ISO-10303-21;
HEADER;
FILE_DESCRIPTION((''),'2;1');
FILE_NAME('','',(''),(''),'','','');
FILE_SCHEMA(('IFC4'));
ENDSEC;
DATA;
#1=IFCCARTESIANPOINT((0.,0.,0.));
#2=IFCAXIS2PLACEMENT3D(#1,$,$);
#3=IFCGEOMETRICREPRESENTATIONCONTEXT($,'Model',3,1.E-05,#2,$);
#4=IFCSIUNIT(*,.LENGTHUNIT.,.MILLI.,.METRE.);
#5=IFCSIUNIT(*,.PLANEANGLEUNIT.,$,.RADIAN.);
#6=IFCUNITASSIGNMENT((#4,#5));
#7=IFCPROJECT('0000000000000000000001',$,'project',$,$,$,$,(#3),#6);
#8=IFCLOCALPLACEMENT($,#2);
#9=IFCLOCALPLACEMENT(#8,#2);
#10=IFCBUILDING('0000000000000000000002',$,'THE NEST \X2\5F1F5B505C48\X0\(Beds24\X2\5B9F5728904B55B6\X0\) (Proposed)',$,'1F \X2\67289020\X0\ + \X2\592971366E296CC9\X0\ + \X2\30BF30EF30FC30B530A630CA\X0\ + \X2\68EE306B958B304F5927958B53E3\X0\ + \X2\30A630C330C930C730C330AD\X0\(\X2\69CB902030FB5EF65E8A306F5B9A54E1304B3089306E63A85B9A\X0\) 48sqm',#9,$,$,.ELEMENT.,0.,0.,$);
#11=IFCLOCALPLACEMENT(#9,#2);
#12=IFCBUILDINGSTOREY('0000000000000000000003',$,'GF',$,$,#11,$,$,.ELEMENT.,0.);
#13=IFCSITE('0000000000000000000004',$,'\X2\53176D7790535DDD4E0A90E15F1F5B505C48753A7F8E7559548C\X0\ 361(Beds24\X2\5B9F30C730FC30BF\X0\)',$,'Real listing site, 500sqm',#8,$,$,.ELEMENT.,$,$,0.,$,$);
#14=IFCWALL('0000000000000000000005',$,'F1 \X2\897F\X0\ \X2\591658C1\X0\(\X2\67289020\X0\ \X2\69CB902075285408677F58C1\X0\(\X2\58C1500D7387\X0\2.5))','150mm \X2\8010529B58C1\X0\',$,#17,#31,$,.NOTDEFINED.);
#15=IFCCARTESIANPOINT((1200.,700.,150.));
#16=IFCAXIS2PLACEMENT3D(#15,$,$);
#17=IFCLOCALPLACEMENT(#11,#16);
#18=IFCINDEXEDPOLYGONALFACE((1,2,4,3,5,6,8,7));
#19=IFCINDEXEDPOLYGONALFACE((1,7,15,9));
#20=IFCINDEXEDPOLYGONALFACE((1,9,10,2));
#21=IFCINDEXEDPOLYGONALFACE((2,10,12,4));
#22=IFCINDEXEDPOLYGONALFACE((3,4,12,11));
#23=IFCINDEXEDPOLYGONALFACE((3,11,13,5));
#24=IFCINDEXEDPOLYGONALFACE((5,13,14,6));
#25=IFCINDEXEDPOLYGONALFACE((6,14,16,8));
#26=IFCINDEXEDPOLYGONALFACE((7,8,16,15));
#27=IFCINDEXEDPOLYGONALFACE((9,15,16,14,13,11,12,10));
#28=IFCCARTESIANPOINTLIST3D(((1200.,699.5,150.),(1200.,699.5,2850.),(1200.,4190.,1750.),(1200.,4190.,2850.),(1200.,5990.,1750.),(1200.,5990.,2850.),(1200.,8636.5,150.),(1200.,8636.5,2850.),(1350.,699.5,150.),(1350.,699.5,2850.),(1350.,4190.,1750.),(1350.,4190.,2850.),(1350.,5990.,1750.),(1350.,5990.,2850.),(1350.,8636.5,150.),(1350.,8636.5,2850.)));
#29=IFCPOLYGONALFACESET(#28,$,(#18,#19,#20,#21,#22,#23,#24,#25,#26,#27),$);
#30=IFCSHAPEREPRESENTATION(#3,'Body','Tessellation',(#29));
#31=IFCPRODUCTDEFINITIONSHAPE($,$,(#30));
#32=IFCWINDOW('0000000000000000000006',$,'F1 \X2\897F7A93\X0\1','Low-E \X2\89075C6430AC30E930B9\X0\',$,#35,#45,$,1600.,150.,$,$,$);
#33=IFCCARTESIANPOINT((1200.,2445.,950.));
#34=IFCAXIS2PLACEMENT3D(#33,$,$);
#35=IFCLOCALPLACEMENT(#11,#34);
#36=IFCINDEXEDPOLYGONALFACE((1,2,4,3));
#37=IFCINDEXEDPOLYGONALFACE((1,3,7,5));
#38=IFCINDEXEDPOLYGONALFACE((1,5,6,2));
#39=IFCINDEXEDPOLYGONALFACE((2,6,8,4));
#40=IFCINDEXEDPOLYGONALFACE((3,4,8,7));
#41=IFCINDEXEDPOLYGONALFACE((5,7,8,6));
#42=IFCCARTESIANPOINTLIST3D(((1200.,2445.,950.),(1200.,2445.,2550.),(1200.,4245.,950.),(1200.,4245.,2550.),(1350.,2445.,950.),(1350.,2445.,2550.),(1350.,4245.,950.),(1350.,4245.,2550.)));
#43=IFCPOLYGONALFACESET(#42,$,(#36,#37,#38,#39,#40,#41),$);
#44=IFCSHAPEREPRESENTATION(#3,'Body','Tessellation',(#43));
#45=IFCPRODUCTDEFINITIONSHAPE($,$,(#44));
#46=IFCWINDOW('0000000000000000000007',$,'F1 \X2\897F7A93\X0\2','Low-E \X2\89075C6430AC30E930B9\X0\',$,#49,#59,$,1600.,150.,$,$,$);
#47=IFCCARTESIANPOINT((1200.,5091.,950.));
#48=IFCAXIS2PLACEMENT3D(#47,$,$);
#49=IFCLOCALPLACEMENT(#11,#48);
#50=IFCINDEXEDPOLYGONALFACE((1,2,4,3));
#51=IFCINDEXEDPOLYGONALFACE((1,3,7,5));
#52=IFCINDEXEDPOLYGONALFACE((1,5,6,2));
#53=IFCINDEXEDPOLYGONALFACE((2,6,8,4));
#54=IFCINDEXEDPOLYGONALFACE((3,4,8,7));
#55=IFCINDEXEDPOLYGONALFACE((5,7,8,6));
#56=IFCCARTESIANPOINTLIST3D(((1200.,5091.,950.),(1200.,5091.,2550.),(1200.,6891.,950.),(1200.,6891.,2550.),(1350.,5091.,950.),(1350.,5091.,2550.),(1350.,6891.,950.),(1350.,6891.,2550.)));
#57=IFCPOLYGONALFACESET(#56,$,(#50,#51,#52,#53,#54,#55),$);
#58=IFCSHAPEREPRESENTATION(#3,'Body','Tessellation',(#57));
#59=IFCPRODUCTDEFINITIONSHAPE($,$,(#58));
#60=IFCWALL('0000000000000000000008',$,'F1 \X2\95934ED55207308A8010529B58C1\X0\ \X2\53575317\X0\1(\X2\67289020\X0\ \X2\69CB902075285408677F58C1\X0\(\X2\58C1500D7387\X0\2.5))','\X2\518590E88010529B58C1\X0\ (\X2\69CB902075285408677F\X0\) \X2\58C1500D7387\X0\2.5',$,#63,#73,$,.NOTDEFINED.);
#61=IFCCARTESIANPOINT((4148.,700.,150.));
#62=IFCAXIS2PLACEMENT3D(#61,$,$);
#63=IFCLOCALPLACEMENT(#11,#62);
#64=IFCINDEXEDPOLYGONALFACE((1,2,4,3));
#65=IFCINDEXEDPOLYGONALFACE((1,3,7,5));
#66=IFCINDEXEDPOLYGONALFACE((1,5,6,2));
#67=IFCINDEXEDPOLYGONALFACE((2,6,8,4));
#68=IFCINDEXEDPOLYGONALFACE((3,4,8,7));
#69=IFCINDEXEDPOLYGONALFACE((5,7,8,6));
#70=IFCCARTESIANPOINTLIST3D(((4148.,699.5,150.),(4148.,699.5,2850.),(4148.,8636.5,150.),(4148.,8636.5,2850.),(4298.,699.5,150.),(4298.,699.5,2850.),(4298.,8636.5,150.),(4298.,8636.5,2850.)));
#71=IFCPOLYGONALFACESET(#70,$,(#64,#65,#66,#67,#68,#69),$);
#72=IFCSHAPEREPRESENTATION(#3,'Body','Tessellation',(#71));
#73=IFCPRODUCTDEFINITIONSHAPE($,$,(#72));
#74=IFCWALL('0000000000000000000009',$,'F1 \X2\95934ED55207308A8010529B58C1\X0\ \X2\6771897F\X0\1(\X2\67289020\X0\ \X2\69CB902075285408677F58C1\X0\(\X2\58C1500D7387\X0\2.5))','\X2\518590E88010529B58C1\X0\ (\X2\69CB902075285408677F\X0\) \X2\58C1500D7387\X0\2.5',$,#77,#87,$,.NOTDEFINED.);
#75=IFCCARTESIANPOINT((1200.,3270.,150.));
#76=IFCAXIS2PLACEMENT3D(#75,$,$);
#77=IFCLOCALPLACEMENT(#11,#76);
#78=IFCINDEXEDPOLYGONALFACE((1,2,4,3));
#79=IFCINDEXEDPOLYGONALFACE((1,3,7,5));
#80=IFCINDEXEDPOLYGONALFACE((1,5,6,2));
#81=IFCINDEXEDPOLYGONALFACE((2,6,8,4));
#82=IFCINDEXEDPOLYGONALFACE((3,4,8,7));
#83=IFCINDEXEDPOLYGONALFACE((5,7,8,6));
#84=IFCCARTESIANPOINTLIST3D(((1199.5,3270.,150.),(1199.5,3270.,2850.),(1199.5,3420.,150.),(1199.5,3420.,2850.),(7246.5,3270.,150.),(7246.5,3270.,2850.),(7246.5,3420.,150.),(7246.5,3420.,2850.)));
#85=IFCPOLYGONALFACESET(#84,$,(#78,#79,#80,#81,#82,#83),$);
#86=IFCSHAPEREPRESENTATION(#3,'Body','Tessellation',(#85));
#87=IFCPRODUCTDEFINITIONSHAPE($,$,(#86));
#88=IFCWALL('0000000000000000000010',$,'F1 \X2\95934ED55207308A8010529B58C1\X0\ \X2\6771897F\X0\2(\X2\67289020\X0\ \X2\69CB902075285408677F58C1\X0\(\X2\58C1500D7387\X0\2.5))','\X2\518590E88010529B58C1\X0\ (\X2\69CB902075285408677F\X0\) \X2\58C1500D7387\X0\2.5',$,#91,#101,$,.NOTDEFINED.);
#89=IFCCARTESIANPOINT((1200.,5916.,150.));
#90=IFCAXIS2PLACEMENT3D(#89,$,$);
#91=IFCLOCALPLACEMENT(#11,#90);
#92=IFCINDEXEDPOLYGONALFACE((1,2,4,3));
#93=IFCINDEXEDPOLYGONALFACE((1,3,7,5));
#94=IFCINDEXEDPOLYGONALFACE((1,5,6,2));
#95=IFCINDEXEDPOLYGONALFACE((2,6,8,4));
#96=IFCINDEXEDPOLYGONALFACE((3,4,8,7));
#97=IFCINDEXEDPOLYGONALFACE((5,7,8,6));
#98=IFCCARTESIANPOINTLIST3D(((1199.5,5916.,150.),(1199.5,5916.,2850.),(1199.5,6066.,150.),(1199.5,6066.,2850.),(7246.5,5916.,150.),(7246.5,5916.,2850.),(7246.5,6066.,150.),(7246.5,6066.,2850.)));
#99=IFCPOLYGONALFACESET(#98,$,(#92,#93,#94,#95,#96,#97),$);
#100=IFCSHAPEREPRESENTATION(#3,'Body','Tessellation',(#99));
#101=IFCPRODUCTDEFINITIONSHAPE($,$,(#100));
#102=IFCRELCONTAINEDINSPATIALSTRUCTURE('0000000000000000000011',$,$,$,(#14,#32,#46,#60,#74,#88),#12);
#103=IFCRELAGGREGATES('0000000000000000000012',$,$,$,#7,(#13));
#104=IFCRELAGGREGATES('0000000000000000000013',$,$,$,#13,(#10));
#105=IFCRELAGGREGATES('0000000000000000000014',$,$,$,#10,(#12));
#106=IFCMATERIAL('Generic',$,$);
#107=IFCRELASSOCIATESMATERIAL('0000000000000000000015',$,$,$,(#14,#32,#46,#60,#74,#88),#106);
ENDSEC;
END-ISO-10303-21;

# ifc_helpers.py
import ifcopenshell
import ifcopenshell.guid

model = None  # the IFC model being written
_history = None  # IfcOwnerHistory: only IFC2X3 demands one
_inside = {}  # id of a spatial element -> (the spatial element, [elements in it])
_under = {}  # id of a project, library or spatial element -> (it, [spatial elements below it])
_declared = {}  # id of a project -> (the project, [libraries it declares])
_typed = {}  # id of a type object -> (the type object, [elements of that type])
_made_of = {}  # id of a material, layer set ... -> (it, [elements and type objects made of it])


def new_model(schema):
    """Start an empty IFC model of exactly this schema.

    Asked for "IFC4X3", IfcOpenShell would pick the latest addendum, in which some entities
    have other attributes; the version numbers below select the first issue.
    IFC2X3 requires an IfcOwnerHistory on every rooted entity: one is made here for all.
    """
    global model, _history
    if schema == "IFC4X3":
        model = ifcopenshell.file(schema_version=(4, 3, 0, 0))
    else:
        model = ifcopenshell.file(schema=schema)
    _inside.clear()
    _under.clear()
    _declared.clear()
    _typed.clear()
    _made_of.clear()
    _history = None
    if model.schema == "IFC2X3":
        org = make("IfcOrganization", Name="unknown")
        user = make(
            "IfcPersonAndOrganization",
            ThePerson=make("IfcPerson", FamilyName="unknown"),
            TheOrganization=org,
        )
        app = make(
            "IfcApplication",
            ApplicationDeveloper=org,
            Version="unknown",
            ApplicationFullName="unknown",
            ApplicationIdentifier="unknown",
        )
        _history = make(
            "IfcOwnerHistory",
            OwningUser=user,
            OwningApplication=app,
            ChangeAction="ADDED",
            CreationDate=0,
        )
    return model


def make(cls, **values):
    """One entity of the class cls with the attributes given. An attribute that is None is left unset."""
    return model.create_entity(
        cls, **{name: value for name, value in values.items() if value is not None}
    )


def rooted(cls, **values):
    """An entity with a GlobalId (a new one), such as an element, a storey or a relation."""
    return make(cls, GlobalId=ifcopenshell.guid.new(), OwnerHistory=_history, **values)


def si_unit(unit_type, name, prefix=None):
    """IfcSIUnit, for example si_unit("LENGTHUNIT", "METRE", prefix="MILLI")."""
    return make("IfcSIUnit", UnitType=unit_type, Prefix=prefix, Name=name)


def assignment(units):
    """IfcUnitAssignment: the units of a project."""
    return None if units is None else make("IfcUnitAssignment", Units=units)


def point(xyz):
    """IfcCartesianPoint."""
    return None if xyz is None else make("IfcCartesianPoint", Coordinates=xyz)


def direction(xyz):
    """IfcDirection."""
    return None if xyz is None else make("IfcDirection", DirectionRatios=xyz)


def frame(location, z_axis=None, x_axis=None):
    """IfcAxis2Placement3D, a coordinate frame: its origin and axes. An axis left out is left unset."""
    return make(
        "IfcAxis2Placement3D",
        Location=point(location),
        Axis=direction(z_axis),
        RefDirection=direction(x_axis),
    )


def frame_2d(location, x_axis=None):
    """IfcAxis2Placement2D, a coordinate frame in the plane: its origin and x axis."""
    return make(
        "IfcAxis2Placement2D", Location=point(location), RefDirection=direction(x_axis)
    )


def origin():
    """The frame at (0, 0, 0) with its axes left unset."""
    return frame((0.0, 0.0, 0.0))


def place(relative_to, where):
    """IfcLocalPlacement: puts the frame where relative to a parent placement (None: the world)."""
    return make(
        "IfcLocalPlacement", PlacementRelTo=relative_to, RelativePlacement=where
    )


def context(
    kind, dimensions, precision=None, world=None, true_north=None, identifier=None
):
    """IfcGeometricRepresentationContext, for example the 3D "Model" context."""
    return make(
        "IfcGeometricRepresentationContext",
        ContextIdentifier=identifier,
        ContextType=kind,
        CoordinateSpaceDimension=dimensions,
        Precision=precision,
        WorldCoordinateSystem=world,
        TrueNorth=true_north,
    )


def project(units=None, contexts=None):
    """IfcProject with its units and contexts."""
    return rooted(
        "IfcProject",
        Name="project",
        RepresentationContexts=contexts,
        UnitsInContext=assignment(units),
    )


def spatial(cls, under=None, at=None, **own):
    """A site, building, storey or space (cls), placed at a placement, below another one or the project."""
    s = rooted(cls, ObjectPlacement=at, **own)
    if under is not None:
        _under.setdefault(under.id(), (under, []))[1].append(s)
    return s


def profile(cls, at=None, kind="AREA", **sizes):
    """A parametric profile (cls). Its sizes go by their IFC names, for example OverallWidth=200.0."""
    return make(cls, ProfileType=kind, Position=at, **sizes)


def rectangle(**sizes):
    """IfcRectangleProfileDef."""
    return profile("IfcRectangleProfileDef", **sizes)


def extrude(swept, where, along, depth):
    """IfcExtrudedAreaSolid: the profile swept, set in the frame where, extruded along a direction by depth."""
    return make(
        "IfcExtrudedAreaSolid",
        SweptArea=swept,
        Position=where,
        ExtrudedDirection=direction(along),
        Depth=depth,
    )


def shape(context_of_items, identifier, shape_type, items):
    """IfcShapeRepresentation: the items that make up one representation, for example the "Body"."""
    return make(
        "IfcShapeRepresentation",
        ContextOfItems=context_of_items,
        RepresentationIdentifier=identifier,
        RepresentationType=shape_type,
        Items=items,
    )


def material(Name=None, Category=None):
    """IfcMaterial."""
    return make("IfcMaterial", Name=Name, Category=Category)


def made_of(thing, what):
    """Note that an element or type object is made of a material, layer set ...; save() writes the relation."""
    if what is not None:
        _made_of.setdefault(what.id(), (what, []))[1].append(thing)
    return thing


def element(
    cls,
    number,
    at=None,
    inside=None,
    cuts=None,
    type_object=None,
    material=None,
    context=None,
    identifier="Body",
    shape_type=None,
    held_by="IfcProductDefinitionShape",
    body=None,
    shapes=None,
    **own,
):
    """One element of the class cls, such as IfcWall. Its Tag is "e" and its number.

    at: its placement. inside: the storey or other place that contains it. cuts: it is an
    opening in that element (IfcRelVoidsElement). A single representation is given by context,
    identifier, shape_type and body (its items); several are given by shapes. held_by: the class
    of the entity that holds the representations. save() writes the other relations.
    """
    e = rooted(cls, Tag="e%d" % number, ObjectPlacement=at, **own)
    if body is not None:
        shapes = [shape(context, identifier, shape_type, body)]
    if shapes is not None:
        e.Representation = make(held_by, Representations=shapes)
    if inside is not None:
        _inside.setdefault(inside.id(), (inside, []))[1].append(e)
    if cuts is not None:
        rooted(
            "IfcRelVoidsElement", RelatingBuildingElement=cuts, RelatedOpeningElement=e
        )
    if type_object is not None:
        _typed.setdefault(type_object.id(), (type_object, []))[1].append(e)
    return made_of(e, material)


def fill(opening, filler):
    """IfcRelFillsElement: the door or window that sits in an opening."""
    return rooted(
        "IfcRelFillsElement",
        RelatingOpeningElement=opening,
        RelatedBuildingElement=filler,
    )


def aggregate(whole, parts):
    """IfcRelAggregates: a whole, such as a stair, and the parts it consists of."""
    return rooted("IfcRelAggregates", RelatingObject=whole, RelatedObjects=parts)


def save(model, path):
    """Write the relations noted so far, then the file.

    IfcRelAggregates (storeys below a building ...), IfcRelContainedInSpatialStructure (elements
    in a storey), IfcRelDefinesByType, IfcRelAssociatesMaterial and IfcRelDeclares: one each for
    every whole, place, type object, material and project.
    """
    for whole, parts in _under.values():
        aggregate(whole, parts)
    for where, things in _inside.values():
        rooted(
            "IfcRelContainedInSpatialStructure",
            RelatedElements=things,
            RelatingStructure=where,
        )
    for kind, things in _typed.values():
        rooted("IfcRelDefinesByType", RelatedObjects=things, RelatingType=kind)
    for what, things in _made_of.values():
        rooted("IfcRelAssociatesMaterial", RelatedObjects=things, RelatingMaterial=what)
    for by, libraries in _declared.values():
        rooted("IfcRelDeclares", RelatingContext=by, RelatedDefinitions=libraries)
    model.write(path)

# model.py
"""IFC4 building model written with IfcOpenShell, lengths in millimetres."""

from ifc_helpers import new_model, si_unit, frame, frame_2d, origin, place, context, project, spatial, rectangle, extrude, material, element, fill, save


model = new_model("IFC4")

# Units and contexts
model_context = context("Model", 3, precision=1e-05, world=origin())
ifc_project = project(units=[si_unit("LENGTHUNIT", "METRE", prefix="MILLI"), si_unit("PLANEANGLEUNIT", "RADIAN")], contexts=[model_context])

# Site, building, storey
site_placement = place(None, origin())
site = spatial("IfcSite", under=ifc_project, at=site_placement, Name="北海道川上郡弟子屈町美留和 361(Beds24実データ)", ObjectType="Real listing site, 500sqm", CompositionType="ELEMENT", RefElevation=0.0)
building_placement = place(site_placement, origin())
building = spatial("IfcBuilding", under=site, at=building_placement, Name="THE NEST 弟子屈(Beds24実在運営) (Proposed)", ObjectType="1F 木造 + 天然温泉 + タワーサウナ + 森に開く大開口 + ウッドデッキ(構造・延床は定員からの推定) 48sqm", CompositionType="ELEMENT", ElevationOfRefHeight=0.0, ElevationOfTerrain=0.0)
storey_placement = place(building_placement, origin())
storey = spatial("IfcBuildingStorey", under=building, at=storey_placement, Name="GF", CompositionType="ELEMENT", Elevation=0.0)

# Shared definitions
ifc_material_1 = material(Name="Generic")

# Wall, openings, windows
wall_1_placement = place(storey_placement, frame((1200.0, 700.0, 150.0)))
wall_1 = element("IfcWall", 1, at=wall_1_placement, inside=storey, material=ifc_material_1, Name="F1 西 外壁(木造 構造用合板壁(壁倍率2.5))", Description="150mm 耐力壁", PredefinedType="NOTDEFINED", context=model_context, shape_type="SweptSolid", body=[
    extrude(rectangle(XDim=150.0, YDim=7937.0, at=frame_2d((75.0, 3968.0))), frame((1200.0, 700.0, 150.0)), (0.0, 0.0, 1.0), 2700.0),
])
opening_1_placement = place(storey_placement, frame((1200.0, 2445.0, 950.0)))
opening_1 = element("IfcOpeningElement", 2, at=opening_1_placement, cuts=wall_1, PredefinedType="NOTDEFINED", context=model_context, shape_type="SweptSolid", body=[
    extrude(rectangle(XDim=150.0, YDim=1800.0, at=frame_2d((75.0, 900.0))), frame((1200.0, 2445.0, 950.0)), (0.0, 0.0, 1.0), 1600.0),
])
opening_2_placement = place(storey_placement, frame((1200.0, 5091.0, 950.0)))
opening_2 = element("IfcOpeningElement", 3, at=opening_2_placement, cuts=wall_1, PredefinedType="NOTDEFINED", context=model_context, shape_type="SweptSolid", body=[
    extrude(rectangle(XDim=150.0, YDim=1800.0, at=frame_2d((75.0, 900.0))), frame((1200.0, 5091.0, 950.0)), (0.0, 0.0, 1.0), 1600.0),
])
window_1_placement = place(storey_placement, frame((1200.0, 2445.0, 950.0)))
window_1 = element("IfcWindow", 4, at=window_1_placement, inside=storey, material=ifc_material_1, Name="F1 西窓1", Description="Low-E 複層ガラス", OverallHeight=1600.0, OverallWidth=150.0, context=model_context, shape_type="SweptSolid", body=[
    extrude(rectangle(XDim=150.0, YDim=1800.0, at=frame_2d((75.0, 900.0))), frame((1200.0, 2445.0, 950.0)), (0.0, 0.0, 1.0), 1600.0),
])
fill(opening_1, window_1)
window_2_placement = place(storey_placement, frame((1200.0, 5091.0, 950.0)))
window_2 = element("IfcWindow", 5, at=window_2_placement, inside=storey, material=ifc_material_1, Name="F1 西窓2", Description="Low-E 複層ガラス", OverallHeight=1600.0, OverallWidth=150.0, context=model_context, shape_type="SweptSolid", body=[
    extrude(rectangle(XDim=150.0, YDim=1800.0, at=frame_2d((75.0, 900.0))), frame((1200.0, 5091.0, 950.0)), (0.0, 0.0, 1.0), 1600.0),
])
fill(opening_2, window_2)

# Walls
wall_2_placement = place(storey_placement, frame((4148.0, 700.0, 150.0)))
element("IfcWall", 6, at=wall_2_placement, inside=storey, material=ifc_material_1, Name="F1 間仕切り耐力壁 南北1(木造 構造用合板壁(壁倍率2.5))", Description="内部耐力壁 (構造用合板) 壁倍率2.5", PredefinedType="NOTDEFINED", context=model_context, shape_type="SweptSolid", body=[
    extrude(rectangle(XDim=150.0, YDim=7937.0, at=frame_2d((75.0, 3968.0))), frame((4148.0, 700.0, 150.0)), (0.0, 0.0, 1.0), 2700.0),
])
wall_3_placement = place(storey_placement, frame((1200.0, 3270.0, 150.0)))
element("IfcWall", 7, at=wall_3_placement, inside=storey, material=ifc_material_1, Name="F1 間仕切り耐力壁 東西1(木造 構造用合板壁(壁倍率2.5))", Description="内部耐力壁 (構造用合板) 壁倍率2.5", PredefinedType="NOTDEFINED", context=model_context, shape_type="SweptSolid", body=[
    extrude(rectangle(XDim=6047.0, YDim=150.0, at=frame_2d((3023.0, 75.0))), frame((1200.0, 3270.0, 150.0)), (0.0, 0.0, 1.0), 2700.0),
])
wall_4_placement = place(storey_placement, frame((1200.0, 5916.0, 150.0)))
element("IfcWall", 8, at=wall_4_placement, inside=storey, material=ifc_material_1, Name="F1 間仕切り耐力壁 東西2(木造 構造用合板壁(壁倍率2.5))", Description="内部耐力壁 (構造用合板) 壁倍率2.5", PredefinedType="NOTDEFINED", context=model_context, shape_type="SweptSolid", body=[
    extrude(rectangle(XDim=6047.0, YDim=150.0, at=frame_2d((3023.0, 75.0))), frame((1200.0, 5916.0, 150.0)), (0.0, 0.0, 1.0), 2700.0),
])

save(model, "model.ifc")
